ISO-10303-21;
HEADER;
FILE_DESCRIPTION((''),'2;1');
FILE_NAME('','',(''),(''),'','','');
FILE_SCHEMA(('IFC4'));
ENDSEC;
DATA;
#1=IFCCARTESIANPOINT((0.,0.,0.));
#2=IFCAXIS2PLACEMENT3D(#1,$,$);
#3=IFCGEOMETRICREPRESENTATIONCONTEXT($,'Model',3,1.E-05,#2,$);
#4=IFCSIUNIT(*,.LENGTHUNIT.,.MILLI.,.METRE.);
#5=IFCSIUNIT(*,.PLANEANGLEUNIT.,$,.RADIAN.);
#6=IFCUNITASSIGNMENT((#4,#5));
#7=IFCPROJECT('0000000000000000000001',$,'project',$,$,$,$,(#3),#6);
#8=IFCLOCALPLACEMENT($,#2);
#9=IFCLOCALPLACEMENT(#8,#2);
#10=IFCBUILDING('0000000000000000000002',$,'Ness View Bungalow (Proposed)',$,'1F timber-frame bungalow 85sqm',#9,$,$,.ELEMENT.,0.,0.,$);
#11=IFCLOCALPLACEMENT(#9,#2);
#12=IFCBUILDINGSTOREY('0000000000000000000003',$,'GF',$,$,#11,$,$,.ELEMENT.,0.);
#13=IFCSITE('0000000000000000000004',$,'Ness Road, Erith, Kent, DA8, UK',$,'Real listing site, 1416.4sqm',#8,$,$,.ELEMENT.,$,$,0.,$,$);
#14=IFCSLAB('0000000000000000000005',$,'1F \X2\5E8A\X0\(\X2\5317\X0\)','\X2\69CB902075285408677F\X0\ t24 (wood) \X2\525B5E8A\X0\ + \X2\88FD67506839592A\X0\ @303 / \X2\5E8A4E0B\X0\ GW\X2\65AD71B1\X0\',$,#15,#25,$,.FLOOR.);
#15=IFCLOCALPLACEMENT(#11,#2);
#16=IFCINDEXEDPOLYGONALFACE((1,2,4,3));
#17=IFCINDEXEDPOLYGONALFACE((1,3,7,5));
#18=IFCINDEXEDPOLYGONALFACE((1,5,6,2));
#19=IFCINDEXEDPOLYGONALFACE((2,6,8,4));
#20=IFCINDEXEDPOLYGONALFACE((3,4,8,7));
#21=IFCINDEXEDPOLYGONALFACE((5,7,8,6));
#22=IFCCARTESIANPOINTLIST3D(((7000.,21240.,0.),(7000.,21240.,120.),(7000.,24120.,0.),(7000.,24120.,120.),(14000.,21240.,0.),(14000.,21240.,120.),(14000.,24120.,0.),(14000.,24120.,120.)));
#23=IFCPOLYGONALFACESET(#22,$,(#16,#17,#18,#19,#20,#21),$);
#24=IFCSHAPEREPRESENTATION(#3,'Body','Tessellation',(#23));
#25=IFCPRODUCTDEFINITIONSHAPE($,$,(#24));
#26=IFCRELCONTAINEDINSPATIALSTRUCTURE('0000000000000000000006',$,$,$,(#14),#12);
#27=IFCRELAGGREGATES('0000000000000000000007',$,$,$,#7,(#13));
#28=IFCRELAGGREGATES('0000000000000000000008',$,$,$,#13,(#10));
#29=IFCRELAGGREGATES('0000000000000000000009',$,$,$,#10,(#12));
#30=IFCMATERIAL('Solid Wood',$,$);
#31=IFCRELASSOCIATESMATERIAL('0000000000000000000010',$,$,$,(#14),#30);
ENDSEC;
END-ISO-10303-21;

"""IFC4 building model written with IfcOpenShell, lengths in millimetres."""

from ifc_helpers import new_model, si_unit, frame, frame_2d, origin, place, context, project, spatial, rectangle, extrude, material, element, save


model = new_model("IFC4")

# Units and contexts
model_context = context("Model", 3, precision=1e-05, world=origin())
ifc_project = project(units=[si_unit("LENGTHUNIT", "METRE", prefix="MILLI"), si_unit("PLANEANGLEUNIT", "RADIAN")], contexts=[model_context])

# Site, building, storey
site_placement = place(None, origin())
site = spatial("IfcSite", under=ifc_project, at=site_placement, Name="Ness Road, Erith, Kent, DA8, UK", ObjectType="Real listing site, 1416.4sqm", CompositionType="ELEMENT", RefElevation=0.0)
building_placement = place(site_placement, origin())
building = spatial("IfcBuilding", under=site, at=building_placement, Name="Ness View Bungalow (Proposed)", ObjectType="1F timber-frame bungalow 85sqm", CompositionType="ELEMENT", ElevationOfRefHeight=0.0, ElevationOfTerrain=0.0)
storey_placement = place(building_placement, origin())
storey = spatial("IfcBuildingStorey", under=building, at=storey_placement, Name="GF", CompositionType="ELEMENT", Elevation=0.0)

# Slab
ifc_material_1 = material(Name="Solid Wood")
slab_1_placement = place(storey_placement, frame((3500.0, 10620.0, 0.0)))
element("IfcSlab", 1, at=slab_1_placement, inside=storey, material=ifc_material_1, Name="1F 床(北)", Description="構造用合板 t24 (wood) 剛床 + 製材根太 @303 / 床下 GW断熱", PredefinedType="FLOOR", context=model_context, shape_type="SweptSolid", body=[
    extrude(rectangle(XDim=7000.0, YDim=2880.0, at=frame_2d((3500.0, 1440.0))), frame((3500.0, 10620.0, 0.0)), (0.0, 0.0, 1.0), 120.0),
])

save(model, "model.ifc")
